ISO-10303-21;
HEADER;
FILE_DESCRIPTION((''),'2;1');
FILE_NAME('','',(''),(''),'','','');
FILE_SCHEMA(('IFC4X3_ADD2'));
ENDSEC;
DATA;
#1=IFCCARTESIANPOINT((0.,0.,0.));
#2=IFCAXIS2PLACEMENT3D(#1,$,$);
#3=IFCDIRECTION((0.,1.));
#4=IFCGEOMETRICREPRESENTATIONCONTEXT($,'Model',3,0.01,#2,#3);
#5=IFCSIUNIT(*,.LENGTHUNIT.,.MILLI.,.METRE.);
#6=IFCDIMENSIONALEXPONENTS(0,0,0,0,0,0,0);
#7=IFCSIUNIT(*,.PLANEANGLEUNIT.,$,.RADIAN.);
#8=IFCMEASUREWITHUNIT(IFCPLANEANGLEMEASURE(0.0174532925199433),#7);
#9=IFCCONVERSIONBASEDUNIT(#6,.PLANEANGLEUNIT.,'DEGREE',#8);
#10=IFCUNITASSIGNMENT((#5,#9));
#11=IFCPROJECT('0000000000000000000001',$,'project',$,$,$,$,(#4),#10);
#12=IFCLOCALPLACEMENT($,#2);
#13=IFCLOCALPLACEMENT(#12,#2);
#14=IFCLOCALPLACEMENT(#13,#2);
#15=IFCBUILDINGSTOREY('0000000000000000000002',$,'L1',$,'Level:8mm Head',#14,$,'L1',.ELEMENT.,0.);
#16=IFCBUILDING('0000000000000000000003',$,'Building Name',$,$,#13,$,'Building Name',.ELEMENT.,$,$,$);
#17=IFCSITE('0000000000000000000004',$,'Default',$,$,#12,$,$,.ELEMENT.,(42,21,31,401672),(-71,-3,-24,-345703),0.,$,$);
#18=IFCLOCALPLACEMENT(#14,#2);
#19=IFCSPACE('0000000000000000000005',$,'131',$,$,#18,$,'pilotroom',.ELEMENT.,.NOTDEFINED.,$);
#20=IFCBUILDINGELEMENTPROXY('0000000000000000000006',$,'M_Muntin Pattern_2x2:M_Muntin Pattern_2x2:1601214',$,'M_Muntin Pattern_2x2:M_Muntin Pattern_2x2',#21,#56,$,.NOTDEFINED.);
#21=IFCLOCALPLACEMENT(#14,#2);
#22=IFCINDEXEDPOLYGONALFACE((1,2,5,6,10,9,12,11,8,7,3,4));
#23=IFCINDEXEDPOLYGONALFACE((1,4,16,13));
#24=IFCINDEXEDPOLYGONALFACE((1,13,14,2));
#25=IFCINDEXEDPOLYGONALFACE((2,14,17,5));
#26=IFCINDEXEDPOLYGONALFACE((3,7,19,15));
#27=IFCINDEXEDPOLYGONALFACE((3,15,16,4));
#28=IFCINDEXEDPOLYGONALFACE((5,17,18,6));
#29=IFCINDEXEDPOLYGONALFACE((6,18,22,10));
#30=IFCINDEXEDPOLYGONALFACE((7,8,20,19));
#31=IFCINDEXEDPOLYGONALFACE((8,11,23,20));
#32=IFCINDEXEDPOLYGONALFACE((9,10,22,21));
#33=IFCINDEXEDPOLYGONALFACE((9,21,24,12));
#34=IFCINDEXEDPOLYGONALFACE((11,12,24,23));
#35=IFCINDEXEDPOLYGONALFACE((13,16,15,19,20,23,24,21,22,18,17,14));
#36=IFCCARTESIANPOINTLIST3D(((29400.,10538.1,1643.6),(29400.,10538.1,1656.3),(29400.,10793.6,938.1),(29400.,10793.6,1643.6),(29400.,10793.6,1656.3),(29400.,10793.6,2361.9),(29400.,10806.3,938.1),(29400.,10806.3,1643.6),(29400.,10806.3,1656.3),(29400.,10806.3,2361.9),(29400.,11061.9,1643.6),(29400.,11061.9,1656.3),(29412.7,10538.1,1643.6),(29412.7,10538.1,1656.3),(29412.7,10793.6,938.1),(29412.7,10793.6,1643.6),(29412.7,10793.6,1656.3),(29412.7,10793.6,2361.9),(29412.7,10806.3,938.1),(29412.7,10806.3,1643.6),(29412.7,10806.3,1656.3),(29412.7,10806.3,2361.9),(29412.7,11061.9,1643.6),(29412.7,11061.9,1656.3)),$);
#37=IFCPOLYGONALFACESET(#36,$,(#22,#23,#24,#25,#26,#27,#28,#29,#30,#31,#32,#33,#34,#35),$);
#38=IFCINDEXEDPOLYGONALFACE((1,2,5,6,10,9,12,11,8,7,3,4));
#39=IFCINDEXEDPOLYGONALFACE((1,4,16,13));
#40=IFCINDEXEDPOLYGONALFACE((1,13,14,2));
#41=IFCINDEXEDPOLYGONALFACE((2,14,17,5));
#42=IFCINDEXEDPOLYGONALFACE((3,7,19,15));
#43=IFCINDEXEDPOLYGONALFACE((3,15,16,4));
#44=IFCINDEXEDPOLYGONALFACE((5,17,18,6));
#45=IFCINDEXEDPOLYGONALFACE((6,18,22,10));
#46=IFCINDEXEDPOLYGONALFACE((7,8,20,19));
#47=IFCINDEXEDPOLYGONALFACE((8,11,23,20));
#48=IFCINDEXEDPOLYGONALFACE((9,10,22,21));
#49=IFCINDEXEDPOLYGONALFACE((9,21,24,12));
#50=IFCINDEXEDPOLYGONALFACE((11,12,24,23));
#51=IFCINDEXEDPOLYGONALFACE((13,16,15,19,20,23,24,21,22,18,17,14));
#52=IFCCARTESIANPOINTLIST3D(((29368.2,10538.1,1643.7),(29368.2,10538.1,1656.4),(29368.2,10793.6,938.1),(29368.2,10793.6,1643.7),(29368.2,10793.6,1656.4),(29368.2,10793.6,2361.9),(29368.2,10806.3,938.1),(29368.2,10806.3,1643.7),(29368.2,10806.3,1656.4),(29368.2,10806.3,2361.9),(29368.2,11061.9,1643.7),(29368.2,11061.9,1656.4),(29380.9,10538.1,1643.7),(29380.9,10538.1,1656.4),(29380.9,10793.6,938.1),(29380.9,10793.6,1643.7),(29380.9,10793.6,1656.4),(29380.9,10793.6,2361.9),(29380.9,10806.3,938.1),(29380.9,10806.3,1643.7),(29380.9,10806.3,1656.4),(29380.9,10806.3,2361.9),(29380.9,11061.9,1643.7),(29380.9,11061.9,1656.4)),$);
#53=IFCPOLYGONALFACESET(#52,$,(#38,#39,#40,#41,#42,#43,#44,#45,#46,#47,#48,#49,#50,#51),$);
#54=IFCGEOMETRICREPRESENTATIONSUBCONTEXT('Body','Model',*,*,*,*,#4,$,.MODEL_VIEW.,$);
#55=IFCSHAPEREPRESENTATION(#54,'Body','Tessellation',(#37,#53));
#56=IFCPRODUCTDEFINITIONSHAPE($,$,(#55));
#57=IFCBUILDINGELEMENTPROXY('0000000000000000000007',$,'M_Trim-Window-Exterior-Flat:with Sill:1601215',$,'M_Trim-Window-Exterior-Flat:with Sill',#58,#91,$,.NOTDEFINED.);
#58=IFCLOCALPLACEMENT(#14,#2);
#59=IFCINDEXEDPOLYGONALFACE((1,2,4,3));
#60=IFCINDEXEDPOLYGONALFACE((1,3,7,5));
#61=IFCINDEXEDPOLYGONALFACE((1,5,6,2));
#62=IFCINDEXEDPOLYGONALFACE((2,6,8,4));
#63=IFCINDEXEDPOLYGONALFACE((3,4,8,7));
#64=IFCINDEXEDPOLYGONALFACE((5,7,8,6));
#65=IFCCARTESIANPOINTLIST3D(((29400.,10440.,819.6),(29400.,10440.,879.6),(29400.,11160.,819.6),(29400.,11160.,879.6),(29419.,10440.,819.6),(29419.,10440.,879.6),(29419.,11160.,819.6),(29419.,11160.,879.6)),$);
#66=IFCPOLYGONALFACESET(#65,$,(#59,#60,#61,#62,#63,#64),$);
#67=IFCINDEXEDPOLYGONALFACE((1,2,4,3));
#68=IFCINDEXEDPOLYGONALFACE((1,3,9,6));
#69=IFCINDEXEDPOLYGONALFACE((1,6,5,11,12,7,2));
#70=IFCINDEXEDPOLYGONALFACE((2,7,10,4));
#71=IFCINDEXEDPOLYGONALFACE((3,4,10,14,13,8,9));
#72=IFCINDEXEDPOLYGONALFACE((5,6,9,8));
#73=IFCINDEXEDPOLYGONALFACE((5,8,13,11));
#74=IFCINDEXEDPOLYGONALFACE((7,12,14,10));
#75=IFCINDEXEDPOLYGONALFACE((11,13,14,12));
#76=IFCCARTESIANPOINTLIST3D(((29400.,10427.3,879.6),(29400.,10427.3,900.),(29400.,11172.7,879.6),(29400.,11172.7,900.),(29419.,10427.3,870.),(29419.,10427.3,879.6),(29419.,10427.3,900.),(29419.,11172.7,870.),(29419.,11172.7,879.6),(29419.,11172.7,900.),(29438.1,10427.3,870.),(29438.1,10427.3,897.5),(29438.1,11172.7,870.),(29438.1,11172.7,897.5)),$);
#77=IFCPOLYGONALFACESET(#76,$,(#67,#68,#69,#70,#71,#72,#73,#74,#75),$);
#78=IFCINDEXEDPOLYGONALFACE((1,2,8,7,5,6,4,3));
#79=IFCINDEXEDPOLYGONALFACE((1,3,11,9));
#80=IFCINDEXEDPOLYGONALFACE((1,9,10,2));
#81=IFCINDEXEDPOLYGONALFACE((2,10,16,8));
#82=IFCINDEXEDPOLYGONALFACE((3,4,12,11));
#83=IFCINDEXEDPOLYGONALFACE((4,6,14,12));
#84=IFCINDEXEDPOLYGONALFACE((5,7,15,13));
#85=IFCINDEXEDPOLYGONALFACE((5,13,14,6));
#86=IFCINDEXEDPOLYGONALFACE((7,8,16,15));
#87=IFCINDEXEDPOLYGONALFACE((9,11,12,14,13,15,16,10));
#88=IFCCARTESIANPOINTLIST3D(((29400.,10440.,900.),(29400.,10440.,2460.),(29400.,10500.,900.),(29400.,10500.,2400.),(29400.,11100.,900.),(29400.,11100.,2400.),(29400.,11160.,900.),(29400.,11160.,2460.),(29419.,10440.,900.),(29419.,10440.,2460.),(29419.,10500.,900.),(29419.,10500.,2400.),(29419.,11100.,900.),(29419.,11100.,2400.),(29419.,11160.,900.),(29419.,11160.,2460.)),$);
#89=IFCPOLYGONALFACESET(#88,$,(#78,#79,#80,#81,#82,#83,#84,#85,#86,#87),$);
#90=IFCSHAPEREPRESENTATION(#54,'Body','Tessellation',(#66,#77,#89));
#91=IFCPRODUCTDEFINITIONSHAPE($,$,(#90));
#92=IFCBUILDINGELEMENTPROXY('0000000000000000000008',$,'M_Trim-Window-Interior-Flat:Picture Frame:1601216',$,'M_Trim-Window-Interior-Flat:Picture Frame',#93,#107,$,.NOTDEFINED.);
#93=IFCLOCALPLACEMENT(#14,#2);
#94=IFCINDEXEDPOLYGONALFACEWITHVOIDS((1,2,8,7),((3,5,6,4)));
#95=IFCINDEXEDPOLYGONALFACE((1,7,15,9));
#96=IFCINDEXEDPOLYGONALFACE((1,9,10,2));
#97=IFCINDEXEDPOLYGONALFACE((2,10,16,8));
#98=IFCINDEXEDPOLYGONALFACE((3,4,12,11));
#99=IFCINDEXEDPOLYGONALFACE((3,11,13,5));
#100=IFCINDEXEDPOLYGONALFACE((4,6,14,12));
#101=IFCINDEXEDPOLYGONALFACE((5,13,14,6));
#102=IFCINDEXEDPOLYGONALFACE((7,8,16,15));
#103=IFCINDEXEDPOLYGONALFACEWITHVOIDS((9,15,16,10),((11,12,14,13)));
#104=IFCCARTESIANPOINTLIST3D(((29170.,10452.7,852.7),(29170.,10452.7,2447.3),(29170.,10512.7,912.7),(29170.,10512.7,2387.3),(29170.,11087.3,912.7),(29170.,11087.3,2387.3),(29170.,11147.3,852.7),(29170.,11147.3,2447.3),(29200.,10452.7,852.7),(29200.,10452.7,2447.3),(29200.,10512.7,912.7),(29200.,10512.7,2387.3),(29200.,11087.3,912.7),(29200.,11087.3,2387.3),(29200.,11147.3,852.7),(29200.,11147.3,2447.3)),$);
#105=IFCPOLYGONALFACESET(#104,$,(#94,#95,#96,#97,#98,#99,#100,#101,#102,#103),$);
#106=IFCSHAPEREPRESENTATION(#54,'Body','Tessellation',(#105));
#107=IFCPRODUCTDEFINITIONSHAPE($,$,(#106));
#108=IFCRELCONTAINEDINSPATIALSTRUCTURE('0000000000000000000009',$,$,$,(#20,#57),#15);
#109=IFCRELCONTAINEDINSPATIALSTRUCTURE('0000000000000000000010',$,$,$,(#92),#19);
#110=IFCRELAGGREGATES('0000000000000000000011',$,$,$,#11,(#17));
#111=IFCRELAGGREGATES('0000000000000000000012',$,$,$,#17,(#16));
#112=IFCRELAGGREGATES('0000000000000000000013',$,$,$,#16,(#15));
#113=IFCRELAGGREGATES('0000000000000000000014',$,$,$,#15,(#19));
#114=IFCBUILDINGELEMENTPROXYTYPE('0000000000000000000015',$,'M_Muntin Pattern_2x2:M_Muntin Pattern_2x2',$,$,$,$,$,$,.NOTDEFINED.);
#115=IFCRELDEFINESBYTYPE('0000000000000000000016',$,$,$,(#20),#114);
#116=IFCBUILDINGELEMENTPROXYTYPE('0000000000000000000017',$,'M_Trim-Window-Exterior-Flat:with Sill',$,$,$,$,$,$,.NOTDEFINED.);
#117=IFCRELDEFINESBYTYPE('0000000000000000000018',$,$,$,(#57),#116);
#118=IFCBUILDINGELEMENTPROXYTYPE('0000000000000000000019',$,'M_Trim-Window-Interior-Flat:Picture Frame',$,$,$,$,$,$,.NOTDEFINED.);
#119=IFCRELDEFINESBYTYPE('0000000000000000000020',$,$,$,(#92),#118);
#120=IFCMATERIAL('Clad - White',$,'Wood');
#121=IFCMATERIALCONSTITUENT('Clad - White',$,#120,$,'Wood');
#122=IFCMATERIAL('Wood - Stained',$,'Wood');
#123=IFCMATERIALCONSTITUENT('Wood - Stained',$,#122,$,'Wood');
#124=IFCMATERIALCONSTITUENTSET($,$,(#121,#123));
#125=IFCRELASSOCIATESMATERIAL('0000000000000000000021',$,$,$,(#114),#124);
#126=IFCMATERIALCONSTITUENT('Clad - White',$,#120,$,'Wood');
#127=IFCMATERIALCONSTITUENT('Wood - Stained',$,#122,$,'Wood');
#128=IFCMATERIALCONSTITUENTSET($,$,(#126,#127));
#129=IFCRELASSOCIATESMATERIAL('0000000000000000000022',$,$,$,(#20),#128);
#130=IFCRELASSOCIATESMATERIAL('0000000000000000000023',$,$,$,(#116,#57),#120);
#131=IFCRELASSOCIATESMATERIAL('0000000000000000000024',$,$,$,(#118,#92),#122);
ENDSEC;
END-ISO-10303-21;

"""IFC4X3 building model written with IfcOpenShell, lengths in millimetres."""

from ifc_helpers import new_model, entity, si_unit, converted_unit, direction, frame, frame_2d, origin, place, context, subcontext, project, spatial, polyline, rectangle, outline, extrude, source, transform, mapped, material, constituent, constituent_set, type_object, type_shapes, element, save


model = new_model("IFC4X3")

# Units and contexts
model_context = context("Model", 3, precision=0.01, world=origin(), true_north=direction((0.0, 1.0)))
body_context = subcontext(model_context, "Body", "Model", "MODEL_VIEW")
ifc_project = project(units=[si_unit("LENGTHUNIT", "METRE", prefix="MILLI"), converted_unit("PLANEANGLEUNIT", "DEGREE", entity("IfcPlaneAngleMeasure", 0.0174532925199433), si_unit("PLANEANGLEUNIT", "RADIAN"), dimensions=[0, 0, 0, 0, 0, 0, 0])], contexts=[model_context])

# Site, building, storey
site_placement = place(None, origin())
site = spatial("IfcSite", under=ifc_project, at=site_placement, Name="Default", CompositionType="ELEMENT", RefLatitude=(42, 21, 31, 401672), RefLongitude=(-71, -3, -24, -345703), RefElevation=0.0)
building_placement = place(site_placement, origin())
building = spatial("IfcBuilding", under=site, at=building_placement, Name="Building Name", LongName="Building Name", CompositionType="ELEMENT")
storey_placement = place(building_placement, origin())
storey = spatial("IfcBuildingStorey", under=building, at=storey_placement, Name="L1", ObjectType="Level:8mm Head", LongName="L1", CompositionType="ELEMENT", Elevation=0.0)

# Building element proxies
ifc_material_1 = material(Name="Clad - White", Category="Wood")
ifc_constituent_1 = constituent(ifc_material_1, Name="Clad - White", Category="Wood")
ifc_material_2 = material(Name="Wood - Stained", Category="Wood")
ifc_constituent_2 = constituent(ifc_material_2, Name="Wood - Stained", Category="Wood")
ifc_constituent_set_1 = constituent_set(constituents=[ifc_constituent_1, ifc_constituent_2])
ifc_constituent_3 = constituent(ifc_material_1, Name="Clad - White", Category="Wood")
ifc_constituent_4 = constituent(ifc_material_2, Name="Wood - Stained", Category="Wood")
ifc_constituent_set_2 = constituent_set(constituents=[ifc_constituent_3, ifc_constituent_4])
building_element_proxy_type_1 = type_object("IfcBuildingElementProxyType", Name="M_Muntin Pattern_2x2:M_Muntin Pattern_2x2", PredefinedType="NOTDEFINED", material=ifc_constituent_set_2)
shared_shape_1 = source(origin(), body_context, "Body", "SweptSolid", [
    extrude(outline(polyline([(6.4, -6.4), (711.9, -6.4), (711.9, 6.3), (6.4, 6.3), (6.4, 261.9), (-6.3, 261.9), (-6.3, 6.3), (-711.9, 6.3), (-711.9, -6.4), (-6.3, -6.4), (-6.3, -261.9), (6.4, -261.9), (6.4, -6.4)])), frame((0.0, -22.2, 711.9), z_axis=(0.0, 1.0, 0.0), x_axis=(0.0, 0.0, 1.0)), (0.0, 0.0, 1.0), 12.7),
    extrude(outline(polyline([(6.4, -6.4), (711.9, -6.4), (711.9, 6.3), (6.4, 6.3), (6.4, 261.9), (-6.3, 261.9), (-6.3, 6.3), (-711.9, 6.3), (-711.9, -6.4), (-6.3, -6.4), (-6.3, -261.9), (6.4, -261.9), (6.4, -6.4)])), frame((0.0, 9.5, 711.9), z_axis=(0.0, 1.0, 0.0), x_axis=(0.0, 0.0, 1.0)), (0.0, 0.0, 1.0), 12.7),
])
type_shapes(building_element_proxy_type_1, [shared_shape_1])
proxy_1_placement = place(storey_placement, frame((29390.5, 10800.0, 938.1), z_axis=(0.0, 0.0, 1.0), x_axis=(0.0, 1.0, 0.0)))
element("IfcBuildingElementProxy", 1, at=proxy_1_placement, inside=storey, type_object=building_element_proxy_type_1, material=ifc_constituent_set_1, Name="M_Muntin Pattern_2x2:M_Muntin Pattern_2x2:1601214", ObjectType="M_Muntin Pattern_2x2:M_Muntin Pattern_2x2", PredefinedType="NOTDEFINED", context=body_context, shape_type="MappedRepresentation", body=[
    mapped(shared_shape_1, transform((0.0, 0.0, 0.0), scale=1.0)),
])
building_element_proxy_type_2 = type_object("IfcBuildingElementProxyType", Name="M_Trim-Window-Exterior-Flat:with Sill", PredefinedType="NOTDEFINED", material=ifc_material_1)
shared_shape_2 = source(origin(), body_context, "Body", "SweptSolid", [
    extrude(rectangle(XDim=720.0, YDim=60.0, at=frame_2d((0.0, 0.0), x_axis=(1.0, 0.0))), frame((0.0, -1550.4, 0.0), z_axis=(0.0, 0.0, 1.0), x_axis=(-1.0, 0.0, 0.0)), (0.0, 0.0, 1.0), 19.1),
    extrude(outline(polyline([(-19.0, -15.2), (0.0, -15.2), (0.0, -5.7), (19.0, -5.7), (19.0, 14.8), (0.0, 14.8), (-19.0, 12.3), (-19.0, -15.2)])), frame((-372.7, -1514.8, 19.0), z_axis=(1.0, 0.0, 0.0), x_axis=(0.0, 0.0, -1.0)), (0.0, 0.0, 1.0), 745.4),
    extrude(outline(polyline([(-795.0, -360.0), (765.0, -360.0), (765.0, -300.0), (-735.0, -300.0), (-735.0, 300.0), (765.0, 300.0), (765.0, 360.0), (-795.0, 360.0), (-795.0, -360.0)])), frame((0.0, -735.0, 0.0), z_axis=(0.0, 0.0, 1.0), x_axis=(0.0, -1.0, 0.0)), (0.0, 0.0, 1.0), 19.1),
])
type_shapes(building_element_proxy_type_2, [shared_shape_2])
proxy_2_placement = place(storey_placement, frame((29400.0, 10800.0, 2400.0), z_axis=(1.0, 0.0, 0.0), x_axis=(0.0, 1.0, 0.0)))
element("IfcBuildingElementProxy", 2, at=proxy_2_placement, inside=storey, type_object=building_element_proxy_type_2, material=ifc_material_1, Name="M_Trim-Window-Exterior-Flat:with Sill:1601215", ObjectType="M_Trim-Window-Exterior-Flat:with Sill", PredefinedType="NOTDEFINED", context=body_context, shape_type="MappedRepresentation", body=[
    mapped(shared_shape_2, transform((0.0, 0.0, 0.0), scale=1.0)),
])

# Shared definitions
space_placement = place(storey_placement, origin())
space = spatial("IfcSpace", under=storey, at=space_placement, Name="131", LongName="pilotroom", CompositionType="ELEMENT", PredefinedType="NOTDEFINED")

# Building element proxy
building_element_proxy_type_3 = type_object("IfcBuildingElementProxyType", Name="M_Trim-Window-Interior-Flat:Picture Frame", PredefinedType="NOTDEFINED", material=ifc_material_2)
shared_shape_3 = source(origin(), body_context, "Body", "SweptSolid", [
    extrude(outline(polyline([(-347.3, -797.3), (347.3, -797.3), (347.3, 797.3), (-347.3, 797.3), (-347.3, -797.3)]), holes=[polyline([(-287.3, -737.3), (-287.3, 737.3), (287.3, 737.3), (287.3, -737.3), (-287.3, -737.3)])]), frame((0.0, -750.0, 0.0), z_axis=(0.0, 0.0, 1.0), x_axis=(-1.0, 0.0, 0.0)), (0.0, 0.0, 1.0), 30.0),
])
type_shapes(building_element_proxy_type_3, [shared_shape_3])
proxy_3_placement = place(space_placement, frame((29200.0, 10800.0, 2400.0), z_axis=(-1.0, 0.0, 0.0), x_axis=(0.0, -1.0, 0.0)))
element("IfcBuildingElementProxy", 3, at=proxy_3_placement, inside=space, type_object=building_element_proxy_type_3, material=ifc_material_2, Name="M_Trim-Window-Interior-Flat:Picture Frame:1601216", ObjectType="M_Trim-Window-Interior-Flat:Picture Frame", PredefinedType="NOTDEFINED", context=body_context, shape_type="MappedRepresentation", body=[
    mapped(shared_shape_3, transform((0.0, 0.0, 0.0), scale=1.0)),
])

save(model, "model.ifc")
